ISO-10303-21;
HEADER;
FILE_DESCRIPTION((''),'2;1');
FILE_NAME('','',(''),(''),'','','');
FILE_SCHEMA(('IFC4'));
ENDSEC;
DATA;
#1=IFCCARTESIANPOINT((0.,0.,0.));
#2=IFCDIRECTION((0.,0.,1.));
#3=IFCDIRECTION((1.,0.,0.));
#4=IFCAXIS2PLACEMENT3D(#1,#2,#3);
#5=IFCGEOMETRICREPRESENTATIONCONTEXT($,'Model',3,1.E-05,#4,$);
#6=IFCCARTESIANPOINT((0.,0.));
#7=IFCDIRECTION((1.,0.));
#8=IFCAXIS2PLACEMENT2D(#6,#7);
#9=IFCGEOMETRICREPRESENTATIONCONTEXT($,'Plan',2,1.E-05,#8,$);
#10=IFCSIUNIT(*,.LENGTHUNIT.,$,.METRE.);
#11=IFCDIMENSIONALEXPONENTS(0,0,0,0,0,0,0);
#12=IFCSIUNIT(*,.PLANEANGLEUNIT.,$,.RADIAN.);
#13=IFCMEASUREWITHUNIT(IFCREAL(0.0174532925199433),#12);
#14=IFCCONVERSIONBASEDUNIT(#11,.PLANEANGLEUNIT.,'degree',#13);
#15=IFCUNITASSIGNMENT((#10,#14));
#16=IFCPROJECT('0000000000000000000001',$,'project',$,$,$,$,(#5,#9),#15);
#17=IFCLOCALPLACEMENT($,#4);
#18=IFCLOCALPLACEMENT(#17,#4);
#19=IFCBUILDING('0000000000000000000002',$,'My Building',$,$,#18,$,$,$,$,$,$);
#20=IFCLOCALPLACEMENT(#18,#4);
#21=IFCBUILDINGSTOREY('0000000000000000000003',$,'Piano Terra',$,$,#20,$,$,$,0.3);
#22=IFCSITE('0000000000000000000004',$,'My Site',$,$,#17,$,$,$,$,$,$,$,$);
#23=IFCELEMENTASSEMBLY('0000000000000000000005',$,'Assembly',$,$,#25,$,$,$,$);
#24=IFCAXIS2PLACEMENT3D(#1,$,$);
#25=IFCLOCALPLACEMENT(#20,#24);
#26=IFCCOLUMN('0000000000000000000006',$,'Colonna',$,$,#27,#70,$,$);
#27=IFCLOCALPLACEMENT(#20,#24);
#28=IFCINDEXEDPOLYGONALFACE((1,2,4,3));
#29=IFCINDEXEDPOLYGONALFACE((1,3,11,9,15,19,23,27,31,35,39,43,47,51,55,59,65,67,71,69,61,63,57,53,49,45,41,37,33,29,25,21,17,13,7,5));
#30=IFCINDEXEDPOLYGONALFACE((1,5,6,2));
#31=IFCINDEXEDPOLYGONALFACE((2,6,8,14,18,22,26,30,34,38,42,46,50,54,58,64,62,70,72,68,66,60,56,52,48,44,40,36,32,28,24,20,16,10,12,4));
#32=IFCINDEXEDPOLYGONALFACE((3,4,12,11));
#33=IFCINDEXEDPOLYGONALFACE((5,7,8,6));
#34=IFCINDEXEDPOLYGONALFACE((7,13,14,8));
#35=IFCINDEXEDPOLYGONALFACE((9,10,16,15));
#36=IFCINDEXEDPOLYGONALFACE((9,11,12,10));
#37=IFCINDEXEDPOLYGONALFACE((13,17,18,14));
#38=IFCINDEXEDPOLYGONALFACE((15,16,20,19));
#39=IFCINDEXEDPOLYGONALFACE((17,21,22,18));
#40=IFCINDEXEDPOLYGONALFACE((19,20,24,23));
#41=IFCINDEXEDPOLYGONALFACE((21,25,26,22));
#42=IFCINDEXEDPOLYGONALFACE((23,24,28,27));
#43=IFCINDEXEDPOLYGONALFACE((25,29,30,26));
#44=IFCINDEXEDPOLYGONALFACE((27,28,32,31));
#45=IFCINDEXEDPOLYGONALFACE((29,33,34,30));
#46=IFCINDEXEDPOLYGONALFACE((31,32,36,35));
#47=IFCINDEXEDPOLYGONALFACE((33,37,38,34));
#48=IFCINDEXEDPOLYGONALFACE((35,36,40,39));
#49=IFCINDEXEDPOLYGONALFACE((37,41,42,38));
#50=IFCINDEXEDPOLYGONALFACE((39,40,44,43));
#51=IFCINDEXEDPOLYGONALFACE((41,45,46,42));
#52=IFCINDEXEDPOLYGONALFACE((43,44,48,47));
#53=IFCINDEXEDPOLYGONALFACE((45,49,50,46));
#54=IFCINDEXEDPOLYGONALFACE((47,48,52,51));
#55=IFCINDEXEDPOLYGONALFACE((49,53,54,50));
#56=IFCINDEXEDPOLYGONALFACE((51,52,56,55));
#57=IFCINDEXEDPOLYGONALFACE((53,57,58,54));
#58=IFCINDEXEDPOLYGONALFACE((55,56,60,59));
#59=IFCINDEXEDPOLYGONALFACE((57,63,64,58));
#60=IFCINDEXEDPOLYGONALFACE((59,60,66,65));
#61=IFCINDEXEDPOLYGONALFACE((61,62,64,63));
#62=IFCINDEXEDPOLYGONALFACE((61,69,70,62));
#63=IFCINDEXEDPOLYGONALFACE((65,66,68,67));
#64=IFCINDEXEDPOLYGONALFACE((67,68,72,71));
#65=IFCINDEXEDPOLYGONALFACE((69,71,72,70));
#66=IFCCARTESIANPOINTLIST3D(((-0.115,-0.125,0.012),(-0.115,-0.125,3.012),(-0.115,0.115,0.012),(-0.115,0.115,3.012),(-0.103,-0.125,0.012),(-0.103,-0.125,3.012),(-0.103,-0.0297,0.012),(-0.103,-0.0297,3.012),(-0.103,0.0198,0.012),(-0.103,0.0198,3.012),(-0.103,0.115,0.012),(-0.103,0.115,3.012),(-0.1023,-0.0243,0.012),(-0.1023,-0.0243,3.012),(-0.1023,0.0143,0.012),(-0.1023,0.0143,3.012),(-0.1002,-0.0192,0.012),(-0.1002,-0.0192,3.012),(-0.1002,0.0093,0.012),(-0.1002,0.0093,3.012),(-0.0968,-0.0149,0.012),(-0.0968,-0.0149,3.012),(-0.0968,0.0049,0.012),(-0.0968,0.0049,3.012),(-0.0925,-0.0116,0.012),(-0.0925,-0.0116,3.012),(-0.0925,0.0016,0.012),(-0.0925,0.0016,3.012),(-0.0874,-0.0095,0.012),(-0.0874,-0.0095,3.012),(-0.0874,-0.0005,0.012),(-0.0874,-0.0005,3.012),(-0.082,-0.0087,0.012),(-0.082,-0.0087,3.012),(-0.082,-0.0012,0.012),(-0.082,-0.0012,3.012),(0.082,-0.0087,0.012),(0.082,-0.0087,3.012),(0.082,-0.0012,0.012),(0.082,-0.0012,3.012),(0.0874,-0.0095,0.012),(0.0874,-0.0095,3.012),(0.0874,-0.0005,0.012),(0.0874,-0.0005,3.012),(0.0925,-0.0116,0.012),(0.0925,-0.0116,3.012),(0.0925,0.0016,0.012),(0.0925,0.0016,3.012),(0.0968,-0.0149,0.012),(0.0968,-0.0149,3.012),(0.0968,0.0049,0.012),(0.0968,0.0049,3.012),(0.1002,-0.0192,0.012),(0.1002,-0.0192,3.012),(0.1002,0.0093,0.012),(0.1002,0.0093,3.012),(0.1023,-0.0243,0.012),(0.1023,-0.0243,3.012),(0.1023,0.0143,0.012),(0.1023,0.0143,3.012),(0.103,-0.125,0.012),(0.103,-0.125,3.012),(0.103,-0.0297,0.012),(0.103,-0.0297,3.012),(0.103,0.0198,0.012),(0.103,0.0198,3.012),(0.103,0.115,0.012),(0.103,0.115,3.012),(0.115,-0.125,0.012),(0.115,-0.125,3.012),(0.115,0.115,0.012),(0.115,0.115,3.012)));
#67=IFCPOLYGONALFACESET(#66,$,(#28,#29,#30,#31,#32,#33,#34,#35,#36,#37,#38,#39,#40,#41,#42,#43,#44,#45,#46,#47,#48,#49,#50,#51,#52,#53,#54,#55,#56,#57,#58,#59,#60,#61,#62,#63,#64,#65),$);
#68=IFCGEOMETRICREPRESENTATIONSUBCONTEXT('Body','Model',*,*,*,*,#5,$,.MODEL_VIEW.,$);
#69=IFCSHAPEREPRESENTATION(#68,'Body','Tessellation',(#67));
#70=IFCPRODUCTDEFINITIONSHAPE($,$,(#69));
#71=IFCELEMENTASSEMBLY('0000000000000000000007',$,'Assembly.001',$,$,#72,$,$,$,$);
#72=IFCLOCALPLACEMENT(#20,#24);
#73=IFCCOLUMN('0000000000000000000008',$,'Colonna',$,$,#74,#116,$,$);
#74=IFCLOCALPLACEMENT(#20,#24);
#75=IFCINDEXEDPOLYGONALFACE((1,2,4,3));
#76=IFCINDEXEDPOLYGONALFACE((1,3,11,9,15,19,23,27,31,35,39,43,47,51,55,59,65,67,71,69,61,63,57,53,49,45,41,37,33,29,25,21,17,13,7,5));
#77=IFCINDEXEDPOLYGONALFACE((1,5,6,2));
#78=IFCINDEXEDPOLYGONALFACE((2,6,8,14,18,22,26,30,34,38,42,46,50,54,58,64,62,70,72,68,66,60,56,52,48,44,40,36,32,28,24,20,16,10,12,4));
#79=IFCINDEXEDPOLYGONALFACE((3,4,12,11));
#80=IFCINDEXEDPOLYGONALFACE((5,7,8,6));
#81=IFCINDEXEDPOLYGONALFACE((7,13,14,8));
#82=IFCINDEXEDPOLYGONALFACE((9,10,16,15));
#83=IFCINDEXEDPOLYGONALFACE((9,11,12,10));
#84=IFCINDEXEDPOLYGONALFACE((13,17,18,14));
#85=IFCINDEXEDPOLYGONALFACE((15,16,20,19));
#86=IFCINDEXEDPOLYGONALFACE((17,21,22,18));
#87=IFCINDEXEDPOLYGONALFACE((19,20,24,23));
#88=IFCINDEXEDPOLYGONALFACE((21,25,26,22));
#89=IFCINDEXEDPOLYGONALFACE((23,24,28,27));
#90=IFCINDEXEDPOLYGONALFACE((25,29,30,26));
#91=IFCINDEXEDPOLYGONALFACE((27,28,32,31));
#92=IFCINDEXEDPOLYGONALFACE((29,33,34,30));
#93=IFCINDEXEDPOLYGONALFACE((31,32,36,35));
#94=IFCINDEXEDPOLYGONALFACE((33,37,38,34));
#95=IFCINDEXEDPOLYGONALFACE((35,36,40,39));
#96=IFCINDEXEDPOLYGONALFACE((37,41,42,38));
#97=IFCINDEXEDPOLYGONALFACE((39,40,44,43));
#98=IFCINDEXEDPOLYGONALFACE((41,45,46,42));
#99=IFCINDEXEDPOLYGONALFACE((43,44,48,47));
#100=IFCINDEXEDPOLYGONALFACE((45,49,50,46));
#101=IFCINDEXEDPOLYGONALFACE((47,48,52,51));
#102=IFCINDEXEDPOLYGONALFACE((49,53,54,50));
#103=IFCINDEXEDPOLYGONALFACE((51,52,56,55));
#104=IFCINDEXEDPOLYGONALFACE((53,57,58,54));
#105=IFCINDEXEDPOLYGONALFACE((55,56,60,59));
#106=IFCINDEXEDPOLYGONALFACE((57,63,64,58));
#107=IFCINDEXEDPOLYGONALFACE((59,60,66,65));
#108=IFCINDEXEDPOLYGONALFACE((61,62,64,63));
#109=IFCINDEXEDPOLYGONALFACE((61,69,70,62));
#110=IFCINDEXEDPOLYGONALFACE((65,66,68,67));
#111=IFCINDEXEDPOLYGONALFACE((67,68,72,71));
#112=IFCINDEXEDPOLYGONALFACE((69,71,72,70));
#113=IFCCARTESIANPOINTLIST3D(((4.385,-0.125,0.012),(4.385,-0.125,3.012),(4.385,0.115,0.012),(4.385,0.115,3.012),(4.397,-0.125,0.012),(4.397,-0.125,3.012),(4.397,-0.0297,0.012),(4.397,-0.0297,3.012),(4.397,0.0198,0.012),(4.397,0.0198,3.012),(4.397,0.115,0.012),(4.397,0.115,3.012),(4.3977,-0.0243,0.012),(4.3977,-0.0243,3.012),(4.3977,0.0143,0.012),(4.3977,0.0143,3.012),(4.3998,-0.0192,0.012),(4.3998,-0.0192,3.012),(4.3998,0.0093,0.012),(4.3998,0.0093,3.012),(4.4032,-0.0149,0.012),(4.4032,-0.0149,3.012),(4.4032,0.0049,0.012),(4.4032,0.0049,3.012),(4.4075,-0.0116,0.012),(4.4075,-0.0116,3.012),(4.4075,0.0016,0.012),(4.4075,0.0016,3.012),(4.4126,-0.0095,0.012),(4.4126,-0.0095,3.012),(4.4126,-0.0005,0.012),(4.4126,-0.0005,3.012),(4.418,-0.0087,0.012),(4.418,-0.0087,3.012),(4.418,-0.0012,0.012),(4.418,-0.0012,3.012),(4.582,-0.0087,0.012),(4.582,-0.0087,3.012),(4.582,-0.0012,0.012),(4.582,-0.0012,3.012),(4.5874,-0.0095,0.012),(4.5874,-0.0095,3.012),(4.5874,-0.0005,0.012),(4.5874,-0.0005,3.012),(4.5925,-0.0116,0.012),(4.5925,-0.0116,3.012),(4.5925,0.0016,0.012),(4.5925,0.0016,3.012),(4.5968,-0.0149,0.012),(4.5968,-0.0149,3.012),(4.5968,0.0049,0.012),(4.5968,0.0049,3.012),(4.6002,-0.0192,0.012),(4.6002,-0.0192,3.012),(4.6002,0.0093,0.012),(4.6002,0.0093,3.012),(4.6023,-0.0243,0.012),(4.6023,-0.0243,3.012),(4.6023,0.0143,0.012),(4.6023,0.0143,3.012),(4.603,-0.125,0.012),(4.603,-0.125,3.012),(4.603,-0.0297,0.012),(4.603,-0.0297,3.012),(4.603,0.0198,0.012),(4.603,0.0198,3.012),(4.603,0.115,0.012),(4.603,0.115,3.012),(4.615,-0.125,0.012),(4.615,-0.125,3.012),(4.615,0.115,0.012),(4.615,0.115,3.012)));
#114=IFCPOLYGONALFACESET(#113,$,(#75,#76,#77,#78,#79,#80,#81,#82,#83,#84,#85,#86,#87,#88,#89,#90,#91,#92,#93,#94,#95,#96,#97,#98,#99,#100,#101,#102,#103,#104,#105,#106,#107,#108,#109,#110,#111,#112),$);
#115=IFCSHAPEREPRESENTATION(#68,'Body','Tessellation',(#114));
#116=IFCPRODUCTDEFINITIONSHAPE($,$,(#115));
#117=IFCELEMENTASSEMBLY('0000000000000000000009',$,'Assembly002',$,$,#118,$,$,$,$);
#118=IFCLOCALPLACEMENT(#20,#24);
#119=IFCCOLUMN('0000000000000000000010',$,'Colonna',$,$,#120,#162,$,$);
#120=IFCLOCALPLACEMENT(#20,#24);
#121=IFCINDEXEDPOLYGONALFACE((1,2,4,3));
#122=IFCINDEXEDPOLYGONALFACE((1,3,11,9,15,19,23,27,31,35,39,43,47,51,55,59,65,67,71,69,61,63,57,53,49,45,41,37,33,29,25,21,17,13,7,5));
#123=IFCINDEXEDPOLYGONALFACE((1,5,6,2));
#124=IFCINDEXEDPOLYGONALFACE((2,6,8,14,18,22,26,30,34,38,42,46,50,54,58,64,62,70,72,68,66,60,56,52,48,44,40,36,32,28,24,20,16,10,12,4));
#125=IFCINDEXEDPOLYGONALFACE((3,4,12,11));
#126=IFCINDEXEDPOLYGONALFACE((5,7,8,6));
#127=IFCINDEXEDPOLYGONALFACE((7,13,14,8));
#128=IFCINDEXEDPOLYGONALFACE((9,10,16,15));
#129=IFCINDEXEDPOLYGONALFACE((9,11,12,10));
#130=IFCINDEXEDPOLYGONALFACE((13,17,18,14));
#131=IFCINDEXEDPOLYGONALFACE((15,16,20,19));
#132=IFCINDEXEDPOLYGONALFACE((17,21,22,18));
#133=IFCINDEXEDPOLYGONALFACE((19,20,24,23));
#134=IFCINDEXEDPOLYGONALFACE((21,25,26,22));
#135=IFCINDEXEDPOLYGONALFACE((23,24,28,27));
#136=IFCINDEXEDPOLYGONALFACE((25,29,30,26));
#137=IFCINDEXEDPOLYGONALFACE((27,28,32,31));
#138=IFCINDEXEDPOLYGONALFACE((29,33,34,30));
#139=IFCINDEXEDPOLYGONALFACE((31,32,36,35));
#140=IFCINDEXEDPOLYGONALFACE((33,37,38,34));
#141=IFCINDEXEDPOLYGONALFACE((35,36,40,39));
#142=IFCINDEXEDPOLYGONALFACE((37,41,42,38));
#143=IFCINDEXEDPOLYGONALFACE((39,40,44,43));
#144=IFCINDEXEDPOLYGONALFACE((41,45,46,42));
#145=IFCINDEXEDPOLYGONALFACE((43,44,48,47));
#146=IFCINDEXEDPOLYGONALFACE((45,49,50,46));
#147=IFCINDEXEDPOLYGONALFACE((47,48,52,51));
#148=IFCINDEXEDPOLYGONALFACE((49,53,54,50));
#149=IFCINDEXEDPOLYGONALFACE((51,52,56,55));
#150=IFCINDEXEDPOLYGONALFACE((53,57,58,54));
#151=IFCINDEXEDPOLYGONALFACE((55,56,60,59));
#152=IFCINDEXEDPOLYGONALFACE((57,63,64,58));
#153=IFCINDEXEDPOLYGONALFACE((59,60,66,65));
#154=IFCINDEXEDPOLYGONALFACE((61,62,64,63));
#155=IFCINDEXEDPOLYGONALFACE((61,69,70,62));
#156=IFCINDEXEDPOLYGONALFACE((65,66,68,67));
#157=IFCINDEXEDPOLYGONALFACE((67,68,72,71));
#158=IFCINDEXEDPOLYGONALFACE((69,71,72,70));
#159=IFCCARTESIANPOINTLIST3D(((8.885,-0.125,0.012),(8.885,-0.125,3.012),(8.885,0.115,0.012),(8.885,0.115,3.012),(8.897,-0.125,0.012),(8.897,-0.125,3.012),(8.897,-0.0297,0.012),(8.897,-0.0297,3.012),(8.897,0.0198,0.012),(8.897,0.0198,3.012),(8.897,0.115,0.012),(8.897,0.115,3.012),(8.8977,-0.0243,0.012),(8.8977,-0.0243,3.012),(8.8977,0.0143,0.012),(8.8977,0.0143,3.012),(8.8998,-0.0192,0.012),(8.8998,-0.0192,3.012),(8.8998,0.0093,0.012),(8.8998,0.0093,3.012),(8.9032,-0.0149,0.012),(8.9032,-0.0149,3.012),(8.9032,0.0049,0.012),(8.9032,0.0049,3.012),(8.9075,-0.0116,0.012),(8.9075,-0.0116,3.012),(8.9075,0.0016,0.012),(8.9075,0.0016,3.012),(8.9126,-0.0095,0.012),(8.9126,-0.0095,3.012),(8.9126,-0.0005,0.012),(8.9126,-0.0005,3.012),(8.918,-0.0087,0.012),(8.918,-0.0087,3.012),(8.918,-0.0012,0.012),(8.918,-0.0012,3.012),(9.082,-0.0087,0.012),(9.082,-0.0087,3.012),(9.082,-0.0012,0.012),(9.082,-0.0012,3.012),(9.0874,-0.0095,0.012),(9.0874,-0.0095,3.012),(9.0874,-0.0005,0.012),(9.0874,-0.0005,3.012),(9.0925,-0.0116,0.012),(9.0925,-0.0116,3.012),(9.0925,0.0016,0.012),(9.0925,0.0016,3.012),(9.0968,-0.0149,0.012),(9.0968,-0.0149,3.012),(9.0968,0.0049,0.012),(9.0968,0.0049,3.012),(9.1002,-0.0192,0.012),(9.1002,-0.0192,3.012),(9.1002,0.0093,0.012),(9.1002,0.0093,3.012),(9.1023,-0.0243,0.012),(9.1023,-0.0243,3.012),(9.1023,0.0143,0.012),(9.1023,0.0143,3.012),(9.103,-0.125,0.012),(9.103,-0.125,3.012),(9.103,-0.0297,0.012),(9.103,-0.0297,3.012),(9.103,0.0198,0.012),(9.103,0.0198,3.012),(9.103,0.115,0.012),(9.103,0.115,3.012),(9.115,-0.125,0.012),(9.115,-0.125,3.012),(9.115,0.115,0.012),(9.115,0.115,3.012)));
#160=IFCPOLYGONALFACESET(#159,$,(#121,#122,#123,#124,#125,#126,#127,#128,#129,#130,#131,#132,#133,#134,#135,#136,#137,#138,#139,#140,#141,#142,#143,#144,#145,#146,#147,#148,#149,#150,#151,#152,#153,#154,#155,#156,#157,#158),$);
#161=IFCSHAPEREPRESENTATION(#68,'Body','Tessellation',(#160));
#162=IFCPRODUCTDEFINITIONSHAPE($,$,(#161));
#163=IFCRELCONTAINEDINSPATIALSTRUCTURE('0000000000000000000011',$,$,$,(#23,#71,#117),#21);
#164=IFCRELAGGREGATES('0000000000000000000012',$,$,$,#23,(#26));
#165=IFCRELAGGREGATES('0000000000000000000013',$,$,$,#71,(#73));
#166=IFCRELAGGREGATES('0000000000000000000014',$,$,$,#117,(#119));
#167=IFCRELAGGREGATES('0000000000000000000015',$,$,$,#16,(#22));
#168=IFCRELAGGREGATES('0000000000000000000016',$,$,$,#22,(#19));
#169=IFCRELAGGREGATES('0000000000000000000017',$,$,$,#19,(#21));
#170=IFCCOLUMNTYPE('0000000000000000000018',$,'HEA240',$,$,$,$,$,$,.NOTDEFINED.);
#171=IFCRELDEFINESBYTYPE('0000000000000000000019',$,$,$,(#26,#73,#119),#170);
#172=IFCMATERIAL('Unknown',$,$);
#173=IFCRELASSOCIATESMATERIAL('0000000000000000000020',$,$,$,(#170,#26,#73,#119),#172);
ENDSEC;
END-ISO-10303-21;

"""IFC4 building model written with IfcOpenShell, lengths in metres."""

from ifc_helpers import new_model, entity, si_unit, converted_unit, frame, origin_with_axes, origin_2d_with_axis, place, context, subcontext, project, spatial, i_section, extrude, material, material_profile, profile_set, profile_usage, type_object, element, aggregate, save


model = new_model("IFC4")

# Units and contexts
model_context = context("Model", 3, precision=1e-05, world=origin_with_axes())
plan_context = context("Plan", 2, precision=1e-05, world=origin_2d_with_axis())
body_context = subcontext(model_context, "Body", "Model", "MODEL_VIEW")
ifc_project = project(units=[si_unit("LENGTHUNIT", "METRE"), converted_unit("PLANEANGLEUNIT", "degree", entity("IfcReal", 0.0174532925199433), si_unit("PLANEANGLEUNIT", "RADIAN"), dimensions=[0, 0, 0, 0, 0, 0, 0])], contexts=[model_context, plan_context])

# Site, building, storey
site_placement = place(None, origin_with_axes())
site = spatial("IfcSite", under=ifc_project, at=site_placement, Name="My Site")
building_placement = place(site_placement, origin_with_axes())
building = spatial("IfcBuilding", under=site, at=building_placement, Name="My Building")
storey_placement = place(building_placement, origin_with_axes())
storey = spatial("IfcBuildingStorey", under=building, at=storey_placement, Name="Piano Terra", Elevation=0.3)

# Element assemblies, columns
assembly_1_placement = place(storey_placement, origin_with_axes())
assembly_1 = element("IfcElementAssembly", 1, at=assembly_1_placement, inside=storey, Name="Assembly")
ifc_material_1 = material(Name="Unknown")
ifc_material_profile = material_profile(ifc_material_1, i_section(OverallWidth=0.24, OverallDepth=0.23, WebThickness=0.0075, FlangeThickness=0.012, FilletRadius=0.021))
ifc_profile_set = profile_set([ifc_material_profile])
ifc_profile_usage_1 = profile_usage(ifc_profile_set)
column_type = type_object("IfcColumnType", Name="HEA240", PredefinedType="NOTDEFINED", material=ifc_profile_set)
column_1_placement = place(assembly_1_placement, frame((0.0, -0.005, 0.012), z_axis=(0.0, 0.0, 1.0), x_axis=(0.0, 1.0, 0.0)))
column_1 = element("IfcColumn", 2, at=column_1_placement, type_object=column_type, material=ifc_profile_usage_1, Name="Colonna", context=body_context, shape_type="SweptSolid", body=[
    extrude(i_section(OverallWidth=0.24, OverallDepth=0.23, WebThickness=0.0075, FlangeThickness=0.012, FilletRadius=0.021), origin_with_axes(), (0.0, 0.0, 1.0), 3.0),
])
assembly_2_placement = place(storey_placement, frame((4.5, 0.0, 0.0), z_axis=(0.0, 0.0, 1.0), x_axis=(1.0, 0.0, 0.0)))
assembly_2 = element("IfcElementAssembly", 3, at=assembly_2_placement, inside=storey, Name="Assembly.001")
ifc_profile_usage_2 = profile_usage(ifc_profile_set)
column_2_placement = place(assembly_2_placement, frame((0.0, -0.005, 0.012), z_axis=(0.0, 0.0, 1.0), x_axis=(0.0, 1.0, 0.0)))
column_2 = element("IfcColumn", 4, at=column_2_placement, type_object=column_type, material=ifc_profile_usage_2, Name="Colonna", context=body_context, shape_type="SweptSolid", body=[
    extrude(i_section(OverallWidth=0.24, OverallDepth=0.23, WebThickness=0.0075, FlangeThickness=0.012, FilletRadius=0.021), origin_with_axes(), (0.0, 0.0, 1.0), 3.0),
])
assembly_3_placement = place(storey_placement, frame((9.0, 0.0, 0.0), z_axis=(0.0, 0.0, 1.0), x_axis=(1.0, 0.0, 0.0)))
assembly_3 = element("IfcElementAssembly", 5, at=assembly_3_placement, inside=storey, Name="Assembly002")
ifc_profile_usage_3 = profile_usage(ifc_profile_set)
column_3_placement = place(assembly_3_placement, frame((0.0, -0.005, 0.012), z_axis=(0.0, 0.0, 1.0), x_axis=(0.0, 1.0, 0.0)))
column_3 = element("IfcColumn", 6, at=column_3_placement, type_object=column_type, material=ifc_profile_usage_3, Name="Colonna", context=body_context, shape_type="SweptSolid", body=[
    extrude(i_section(OverallWidth=0.24, OverallDepth=0.23, WebThickness=0.0075, FlangeThickness=0.012, FilletRadius=0.021), origin_with_axes(), (0.0, 0.0, 1.0), 3.0),
])

aggregate(assembly_1, [column_1])
aggregate(assembly_2, [column_2])
aggregate(assembly_3, [column_3])

save(model, "model.ifc")
